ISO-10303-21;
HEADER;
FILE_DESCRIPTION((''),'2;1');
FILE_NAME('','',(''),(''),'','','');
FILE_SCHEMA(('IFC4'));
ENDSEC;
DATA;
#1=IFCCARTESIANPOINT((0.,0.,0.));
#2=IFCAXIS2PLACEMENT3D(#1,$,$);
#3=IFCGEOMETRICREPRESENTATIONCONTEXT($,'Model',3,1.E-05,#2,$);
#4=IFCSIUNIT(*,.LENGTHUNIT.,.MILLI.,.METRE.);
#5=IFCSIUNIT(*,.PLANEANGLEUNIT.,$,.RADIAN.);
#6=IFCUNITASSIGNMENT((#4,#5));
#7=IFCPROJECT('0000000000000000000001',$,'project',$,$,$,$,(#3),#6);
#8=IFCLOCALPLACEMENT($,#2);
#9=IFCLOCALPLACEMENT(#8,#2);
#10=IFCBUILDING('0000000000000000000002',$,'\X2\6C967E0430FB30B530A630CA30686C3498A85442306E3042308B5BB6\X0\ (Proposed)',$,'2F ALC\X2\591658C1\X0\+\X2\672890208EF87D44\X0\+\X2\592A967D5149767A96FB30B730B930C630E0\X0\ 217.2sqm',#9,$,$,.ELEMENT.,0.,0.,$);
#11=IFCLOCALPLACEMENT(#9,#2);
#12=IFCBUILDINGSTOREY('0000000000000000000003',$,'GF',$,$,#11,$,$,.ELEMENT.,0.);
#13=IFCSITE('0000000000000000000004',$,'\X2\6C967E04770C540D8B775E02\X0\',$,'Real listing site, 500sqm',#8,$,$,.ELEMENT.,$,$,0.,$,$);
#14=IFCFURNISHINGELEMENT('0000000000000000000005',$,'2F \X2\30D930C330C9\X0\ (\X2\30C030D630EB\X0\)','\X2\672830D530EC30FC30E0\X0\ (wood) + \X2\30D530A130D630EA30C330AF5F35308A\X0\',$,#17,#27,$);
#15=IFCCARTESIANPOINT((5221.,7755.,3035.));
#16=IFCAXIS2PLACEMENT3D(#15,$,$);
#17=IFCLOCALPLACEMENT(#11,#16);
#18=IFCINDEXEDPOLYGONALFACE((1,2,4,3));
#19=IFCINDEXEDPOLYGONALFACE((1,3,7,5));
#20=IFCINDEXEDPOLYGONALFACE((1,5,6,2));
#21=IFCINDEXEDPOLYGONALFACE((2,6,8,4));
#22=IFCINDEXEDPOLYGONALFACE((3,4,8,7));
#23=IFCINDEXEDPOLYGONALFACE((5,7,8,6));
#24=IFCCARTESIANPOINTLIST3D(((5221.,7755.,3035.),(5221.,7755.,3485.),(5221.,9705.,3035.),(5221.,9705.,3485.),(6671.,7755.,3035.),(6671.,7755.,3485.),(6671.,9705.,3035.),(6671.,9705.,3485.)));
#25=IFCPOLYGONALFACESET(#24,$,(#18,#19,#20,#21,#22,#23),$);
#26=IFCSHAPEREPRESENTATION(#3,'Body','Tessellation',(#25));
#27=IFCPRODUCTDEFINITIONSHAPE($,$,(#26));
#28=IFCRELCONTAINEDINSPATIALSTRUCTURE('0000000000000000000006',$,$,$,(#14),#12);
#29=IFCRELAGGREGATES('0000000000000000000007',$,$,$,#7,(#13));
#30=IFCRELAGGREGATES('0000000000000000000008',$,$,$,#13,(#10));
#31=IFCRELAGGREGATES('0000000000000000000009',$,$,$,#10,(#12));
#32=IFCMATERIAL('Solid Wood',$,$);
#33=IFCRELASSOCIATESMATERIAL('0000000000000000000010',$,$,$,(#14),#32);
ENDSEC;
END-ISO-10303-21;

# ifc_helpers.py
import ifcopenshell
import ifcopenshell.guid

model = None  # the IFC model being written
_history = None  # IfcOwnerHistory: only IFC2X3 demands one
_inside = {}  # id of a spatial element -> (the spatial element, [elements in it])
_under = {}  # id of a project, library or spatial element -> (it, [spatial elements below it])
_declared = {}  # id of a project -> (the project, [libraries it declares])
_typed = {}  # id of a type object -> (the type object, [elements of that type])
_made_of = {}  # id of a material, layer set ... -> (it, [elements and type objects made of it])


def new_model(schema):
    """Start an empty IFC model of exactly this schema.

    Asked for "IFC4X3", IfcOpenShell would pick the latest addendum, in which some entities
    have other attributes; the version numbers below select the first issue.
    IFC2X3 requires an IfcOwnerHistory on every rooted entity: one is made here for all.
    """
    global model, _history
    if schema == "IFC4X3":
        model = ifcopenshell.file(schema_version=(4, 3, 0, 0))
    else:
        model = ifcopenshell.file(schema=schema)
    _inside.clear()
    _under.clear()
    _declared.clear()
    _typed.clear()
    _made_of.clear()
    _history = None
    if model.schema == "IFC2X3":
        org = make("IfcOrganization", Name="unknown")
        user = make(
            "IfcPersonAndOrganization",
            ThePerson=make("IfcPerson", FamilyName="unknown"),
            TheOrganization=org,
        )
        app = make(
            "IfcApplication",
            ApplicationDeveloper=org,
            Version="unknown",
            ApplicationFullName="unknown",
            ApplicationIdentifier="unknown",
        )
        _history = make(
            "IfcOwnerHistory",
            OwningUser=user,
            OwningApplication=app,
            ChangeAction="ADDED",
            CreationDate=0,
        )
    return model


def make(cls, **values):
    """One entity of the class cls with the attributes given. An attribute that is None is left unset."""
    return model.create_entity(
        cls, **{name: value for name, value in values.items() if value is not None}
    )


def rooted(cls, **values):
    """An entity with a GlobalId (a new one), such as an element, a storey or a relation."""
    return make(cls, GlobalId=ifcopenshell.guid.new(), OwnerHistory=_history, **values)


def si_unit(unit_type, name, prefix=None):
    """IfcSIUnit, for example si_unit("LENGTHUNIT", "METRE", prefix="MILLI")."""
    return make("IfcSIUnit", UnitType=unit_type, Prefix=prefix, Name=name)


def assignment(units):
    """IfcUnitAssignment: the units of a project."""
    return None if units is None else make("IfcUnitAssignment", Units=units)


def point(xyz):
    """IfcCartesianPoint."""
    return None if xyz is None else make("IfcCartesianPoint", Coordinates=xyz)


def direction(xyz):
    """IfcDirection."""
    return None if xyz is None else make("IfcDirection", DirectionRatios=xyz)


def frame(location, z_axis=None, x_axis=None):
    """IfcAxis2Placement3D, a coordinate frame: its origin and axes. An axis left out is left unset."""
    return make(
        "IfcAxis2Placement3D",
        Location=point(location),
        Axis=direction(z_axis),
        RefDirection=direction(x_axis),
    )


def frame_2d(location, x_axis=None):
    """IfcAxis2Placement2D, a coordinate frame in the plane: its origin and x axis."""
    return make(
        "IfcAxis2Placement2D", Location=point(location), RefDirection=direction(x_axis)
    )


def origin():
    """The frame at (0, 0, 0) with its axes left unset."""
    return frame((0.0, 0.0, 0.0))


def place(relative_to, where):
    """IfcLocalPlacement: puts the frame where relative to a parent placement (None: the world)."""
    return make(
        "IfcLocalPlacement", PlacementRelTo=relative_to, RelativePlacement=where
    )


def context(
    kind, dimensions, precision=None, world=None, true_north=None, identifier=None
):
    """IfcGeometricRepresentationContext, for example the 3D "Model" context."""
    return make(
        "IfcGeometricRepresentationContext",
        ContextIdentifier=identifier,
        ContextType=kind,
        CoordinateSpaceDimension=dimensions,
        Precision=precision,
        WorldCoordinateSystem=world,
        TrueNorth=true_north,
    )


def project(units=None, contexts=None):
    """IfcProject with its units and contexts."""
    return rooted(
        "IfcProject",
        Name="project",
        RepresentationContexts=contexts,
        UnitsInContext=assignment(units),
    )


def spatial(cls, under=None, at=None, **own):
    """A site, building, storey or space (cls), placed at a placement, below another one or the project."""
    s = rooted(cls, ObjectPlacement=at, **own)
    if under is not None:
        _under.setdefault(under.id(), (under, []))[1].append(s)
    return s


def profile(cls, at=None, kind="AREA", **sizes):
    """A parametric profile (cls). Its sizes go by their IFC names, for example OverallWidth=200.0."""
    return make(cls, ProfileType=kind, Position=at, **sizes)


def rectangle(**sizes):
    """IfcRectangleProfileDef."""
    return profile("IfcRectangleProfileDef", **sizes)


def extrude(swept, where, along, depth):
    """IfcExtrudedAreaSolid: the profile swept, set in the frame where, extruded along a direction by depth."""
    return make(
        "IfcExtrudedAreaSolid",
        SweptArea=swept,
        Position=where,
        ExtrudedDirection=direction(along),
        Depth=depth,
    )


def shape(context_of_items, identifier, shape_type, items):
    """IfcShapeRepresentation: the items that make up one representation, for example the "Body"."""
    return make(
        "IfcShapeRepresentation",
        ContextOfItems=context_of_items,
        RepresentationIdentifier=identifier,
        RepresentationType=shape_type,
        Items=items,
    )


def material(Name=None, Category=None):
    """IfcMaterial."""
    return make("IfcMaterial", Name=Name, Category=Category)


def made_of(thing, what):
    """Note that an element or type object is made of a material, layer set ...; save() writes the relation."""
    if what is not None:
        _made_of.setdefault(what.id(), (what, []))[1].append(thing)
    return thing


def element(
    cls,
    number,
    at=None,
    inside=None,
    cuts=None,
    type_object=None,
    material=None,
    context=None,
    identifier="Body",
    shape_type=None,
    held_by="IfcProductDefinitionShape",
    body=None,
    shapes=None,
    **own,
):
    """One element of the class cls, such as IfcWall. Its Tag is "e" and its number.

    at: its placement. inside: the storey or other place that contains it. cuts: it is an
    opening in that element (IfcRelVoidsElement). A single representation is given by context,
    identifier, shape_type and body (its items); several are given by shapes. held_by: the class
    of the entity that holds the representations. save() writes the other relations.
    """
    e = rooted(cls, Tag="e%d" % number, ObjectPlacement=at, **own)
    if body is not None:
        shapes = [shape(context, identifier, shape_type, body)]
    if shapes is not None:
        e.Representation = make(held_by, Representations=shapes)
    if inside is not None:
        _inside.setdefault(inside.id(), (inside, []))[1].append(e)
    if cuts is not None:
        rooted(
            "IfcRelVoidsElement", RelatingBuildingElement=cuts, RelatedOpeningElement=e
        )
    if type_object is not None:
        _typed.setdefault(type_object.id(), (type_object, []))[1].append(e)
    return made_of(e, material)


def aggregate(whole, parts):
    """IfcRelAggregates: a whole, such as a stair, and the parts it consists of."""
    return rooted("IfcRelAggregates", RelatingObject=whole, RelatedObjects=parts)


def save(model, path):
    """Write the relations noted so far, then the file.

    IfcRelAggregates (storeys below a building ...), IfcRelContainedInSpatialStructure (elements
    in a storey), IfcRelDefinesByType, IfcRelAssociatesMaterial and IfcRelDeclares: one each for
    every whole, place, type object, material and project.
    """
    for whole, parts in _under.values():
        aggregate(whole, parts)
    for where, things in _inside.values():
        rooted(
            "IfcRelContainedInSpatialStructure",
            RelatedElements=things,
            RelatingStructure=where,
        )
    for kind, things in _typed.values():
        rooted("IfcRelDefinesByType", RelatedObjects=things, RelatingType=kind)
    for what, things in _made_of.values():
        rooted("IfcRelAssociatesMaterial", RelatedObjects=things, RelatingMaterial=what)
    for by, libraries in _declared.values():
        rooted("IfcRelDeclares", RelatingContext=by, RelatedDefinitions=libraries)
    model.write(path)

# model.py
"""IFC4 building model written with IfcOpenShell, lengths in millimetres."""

from ifc_helpers import new_model, si_unit, frame, frame_2d, origin, place, context, project, spatial, rectangle, extrude, material, element, save


model = new_model("IFC4")

# Units and contexts
model_context = context("Model", 3, precision=1e-05, world=origin())
ifc_project = project(units=[si_unit("LENGTHUNIT", "METRE", prefix="MILLI"), si_unit("PLANEANGLEUNIT", "RADIAN")], contexts=[model_context])

# Site, building, storey
site_placement = place(None, origin())
site = spatial("IfcSite", under=ifc_project, at=site_placement, Name="沖縄県名護市", ObjectType="Real listing site, 500sqm", CompositionType="ELEMENT", RefElevation=0.0)
building_placement = place(site_placement, origin())
building = spatial("IfcBuilding", under=site, at=building_placement, Name="沖縄・サウナと水風呂のある家 (Proposed)", ObjectType="2F ALC外壁+木造軸組+太陽光発電システム 217.2sqm", CompositionType="ELEMENT", ElevationOfRefHeight=0.0, ElevationOfTerrain=0.0)
storey_placement = place(building_placement, origin())
storey = spatial("IfcBuildingStorey", under=building, at=storey_placement, Name="GF", CompositionType="ELEMENT", Elevation=0.0)

# Shared definitions
ifc_material_1 = material(Name="Solid Wood")

# Furnishing element
furnishing_1_placement = place(storey_placement, frame((5221.0, 7755.0, 3035.0)))
element("IfcFurnishingElement", 1, at=furnishing_1_placement, inside=storey, material=ifc_material_1, Name="2F ベッド (ダブル)", Description="木フレーム (wood) + ファブリック張り", context=model_context, shape_type="SweptSolid", body=[
    extrude(rectangle(XDim=1450.0, YDim=1950.0, at=frame_2d((725.0, 975.0))), frame((5221.0, 7755.0, 3035.0)), (0.0, 0.0, 1.0), 450.0),
])

save(model, "model.ifc")
